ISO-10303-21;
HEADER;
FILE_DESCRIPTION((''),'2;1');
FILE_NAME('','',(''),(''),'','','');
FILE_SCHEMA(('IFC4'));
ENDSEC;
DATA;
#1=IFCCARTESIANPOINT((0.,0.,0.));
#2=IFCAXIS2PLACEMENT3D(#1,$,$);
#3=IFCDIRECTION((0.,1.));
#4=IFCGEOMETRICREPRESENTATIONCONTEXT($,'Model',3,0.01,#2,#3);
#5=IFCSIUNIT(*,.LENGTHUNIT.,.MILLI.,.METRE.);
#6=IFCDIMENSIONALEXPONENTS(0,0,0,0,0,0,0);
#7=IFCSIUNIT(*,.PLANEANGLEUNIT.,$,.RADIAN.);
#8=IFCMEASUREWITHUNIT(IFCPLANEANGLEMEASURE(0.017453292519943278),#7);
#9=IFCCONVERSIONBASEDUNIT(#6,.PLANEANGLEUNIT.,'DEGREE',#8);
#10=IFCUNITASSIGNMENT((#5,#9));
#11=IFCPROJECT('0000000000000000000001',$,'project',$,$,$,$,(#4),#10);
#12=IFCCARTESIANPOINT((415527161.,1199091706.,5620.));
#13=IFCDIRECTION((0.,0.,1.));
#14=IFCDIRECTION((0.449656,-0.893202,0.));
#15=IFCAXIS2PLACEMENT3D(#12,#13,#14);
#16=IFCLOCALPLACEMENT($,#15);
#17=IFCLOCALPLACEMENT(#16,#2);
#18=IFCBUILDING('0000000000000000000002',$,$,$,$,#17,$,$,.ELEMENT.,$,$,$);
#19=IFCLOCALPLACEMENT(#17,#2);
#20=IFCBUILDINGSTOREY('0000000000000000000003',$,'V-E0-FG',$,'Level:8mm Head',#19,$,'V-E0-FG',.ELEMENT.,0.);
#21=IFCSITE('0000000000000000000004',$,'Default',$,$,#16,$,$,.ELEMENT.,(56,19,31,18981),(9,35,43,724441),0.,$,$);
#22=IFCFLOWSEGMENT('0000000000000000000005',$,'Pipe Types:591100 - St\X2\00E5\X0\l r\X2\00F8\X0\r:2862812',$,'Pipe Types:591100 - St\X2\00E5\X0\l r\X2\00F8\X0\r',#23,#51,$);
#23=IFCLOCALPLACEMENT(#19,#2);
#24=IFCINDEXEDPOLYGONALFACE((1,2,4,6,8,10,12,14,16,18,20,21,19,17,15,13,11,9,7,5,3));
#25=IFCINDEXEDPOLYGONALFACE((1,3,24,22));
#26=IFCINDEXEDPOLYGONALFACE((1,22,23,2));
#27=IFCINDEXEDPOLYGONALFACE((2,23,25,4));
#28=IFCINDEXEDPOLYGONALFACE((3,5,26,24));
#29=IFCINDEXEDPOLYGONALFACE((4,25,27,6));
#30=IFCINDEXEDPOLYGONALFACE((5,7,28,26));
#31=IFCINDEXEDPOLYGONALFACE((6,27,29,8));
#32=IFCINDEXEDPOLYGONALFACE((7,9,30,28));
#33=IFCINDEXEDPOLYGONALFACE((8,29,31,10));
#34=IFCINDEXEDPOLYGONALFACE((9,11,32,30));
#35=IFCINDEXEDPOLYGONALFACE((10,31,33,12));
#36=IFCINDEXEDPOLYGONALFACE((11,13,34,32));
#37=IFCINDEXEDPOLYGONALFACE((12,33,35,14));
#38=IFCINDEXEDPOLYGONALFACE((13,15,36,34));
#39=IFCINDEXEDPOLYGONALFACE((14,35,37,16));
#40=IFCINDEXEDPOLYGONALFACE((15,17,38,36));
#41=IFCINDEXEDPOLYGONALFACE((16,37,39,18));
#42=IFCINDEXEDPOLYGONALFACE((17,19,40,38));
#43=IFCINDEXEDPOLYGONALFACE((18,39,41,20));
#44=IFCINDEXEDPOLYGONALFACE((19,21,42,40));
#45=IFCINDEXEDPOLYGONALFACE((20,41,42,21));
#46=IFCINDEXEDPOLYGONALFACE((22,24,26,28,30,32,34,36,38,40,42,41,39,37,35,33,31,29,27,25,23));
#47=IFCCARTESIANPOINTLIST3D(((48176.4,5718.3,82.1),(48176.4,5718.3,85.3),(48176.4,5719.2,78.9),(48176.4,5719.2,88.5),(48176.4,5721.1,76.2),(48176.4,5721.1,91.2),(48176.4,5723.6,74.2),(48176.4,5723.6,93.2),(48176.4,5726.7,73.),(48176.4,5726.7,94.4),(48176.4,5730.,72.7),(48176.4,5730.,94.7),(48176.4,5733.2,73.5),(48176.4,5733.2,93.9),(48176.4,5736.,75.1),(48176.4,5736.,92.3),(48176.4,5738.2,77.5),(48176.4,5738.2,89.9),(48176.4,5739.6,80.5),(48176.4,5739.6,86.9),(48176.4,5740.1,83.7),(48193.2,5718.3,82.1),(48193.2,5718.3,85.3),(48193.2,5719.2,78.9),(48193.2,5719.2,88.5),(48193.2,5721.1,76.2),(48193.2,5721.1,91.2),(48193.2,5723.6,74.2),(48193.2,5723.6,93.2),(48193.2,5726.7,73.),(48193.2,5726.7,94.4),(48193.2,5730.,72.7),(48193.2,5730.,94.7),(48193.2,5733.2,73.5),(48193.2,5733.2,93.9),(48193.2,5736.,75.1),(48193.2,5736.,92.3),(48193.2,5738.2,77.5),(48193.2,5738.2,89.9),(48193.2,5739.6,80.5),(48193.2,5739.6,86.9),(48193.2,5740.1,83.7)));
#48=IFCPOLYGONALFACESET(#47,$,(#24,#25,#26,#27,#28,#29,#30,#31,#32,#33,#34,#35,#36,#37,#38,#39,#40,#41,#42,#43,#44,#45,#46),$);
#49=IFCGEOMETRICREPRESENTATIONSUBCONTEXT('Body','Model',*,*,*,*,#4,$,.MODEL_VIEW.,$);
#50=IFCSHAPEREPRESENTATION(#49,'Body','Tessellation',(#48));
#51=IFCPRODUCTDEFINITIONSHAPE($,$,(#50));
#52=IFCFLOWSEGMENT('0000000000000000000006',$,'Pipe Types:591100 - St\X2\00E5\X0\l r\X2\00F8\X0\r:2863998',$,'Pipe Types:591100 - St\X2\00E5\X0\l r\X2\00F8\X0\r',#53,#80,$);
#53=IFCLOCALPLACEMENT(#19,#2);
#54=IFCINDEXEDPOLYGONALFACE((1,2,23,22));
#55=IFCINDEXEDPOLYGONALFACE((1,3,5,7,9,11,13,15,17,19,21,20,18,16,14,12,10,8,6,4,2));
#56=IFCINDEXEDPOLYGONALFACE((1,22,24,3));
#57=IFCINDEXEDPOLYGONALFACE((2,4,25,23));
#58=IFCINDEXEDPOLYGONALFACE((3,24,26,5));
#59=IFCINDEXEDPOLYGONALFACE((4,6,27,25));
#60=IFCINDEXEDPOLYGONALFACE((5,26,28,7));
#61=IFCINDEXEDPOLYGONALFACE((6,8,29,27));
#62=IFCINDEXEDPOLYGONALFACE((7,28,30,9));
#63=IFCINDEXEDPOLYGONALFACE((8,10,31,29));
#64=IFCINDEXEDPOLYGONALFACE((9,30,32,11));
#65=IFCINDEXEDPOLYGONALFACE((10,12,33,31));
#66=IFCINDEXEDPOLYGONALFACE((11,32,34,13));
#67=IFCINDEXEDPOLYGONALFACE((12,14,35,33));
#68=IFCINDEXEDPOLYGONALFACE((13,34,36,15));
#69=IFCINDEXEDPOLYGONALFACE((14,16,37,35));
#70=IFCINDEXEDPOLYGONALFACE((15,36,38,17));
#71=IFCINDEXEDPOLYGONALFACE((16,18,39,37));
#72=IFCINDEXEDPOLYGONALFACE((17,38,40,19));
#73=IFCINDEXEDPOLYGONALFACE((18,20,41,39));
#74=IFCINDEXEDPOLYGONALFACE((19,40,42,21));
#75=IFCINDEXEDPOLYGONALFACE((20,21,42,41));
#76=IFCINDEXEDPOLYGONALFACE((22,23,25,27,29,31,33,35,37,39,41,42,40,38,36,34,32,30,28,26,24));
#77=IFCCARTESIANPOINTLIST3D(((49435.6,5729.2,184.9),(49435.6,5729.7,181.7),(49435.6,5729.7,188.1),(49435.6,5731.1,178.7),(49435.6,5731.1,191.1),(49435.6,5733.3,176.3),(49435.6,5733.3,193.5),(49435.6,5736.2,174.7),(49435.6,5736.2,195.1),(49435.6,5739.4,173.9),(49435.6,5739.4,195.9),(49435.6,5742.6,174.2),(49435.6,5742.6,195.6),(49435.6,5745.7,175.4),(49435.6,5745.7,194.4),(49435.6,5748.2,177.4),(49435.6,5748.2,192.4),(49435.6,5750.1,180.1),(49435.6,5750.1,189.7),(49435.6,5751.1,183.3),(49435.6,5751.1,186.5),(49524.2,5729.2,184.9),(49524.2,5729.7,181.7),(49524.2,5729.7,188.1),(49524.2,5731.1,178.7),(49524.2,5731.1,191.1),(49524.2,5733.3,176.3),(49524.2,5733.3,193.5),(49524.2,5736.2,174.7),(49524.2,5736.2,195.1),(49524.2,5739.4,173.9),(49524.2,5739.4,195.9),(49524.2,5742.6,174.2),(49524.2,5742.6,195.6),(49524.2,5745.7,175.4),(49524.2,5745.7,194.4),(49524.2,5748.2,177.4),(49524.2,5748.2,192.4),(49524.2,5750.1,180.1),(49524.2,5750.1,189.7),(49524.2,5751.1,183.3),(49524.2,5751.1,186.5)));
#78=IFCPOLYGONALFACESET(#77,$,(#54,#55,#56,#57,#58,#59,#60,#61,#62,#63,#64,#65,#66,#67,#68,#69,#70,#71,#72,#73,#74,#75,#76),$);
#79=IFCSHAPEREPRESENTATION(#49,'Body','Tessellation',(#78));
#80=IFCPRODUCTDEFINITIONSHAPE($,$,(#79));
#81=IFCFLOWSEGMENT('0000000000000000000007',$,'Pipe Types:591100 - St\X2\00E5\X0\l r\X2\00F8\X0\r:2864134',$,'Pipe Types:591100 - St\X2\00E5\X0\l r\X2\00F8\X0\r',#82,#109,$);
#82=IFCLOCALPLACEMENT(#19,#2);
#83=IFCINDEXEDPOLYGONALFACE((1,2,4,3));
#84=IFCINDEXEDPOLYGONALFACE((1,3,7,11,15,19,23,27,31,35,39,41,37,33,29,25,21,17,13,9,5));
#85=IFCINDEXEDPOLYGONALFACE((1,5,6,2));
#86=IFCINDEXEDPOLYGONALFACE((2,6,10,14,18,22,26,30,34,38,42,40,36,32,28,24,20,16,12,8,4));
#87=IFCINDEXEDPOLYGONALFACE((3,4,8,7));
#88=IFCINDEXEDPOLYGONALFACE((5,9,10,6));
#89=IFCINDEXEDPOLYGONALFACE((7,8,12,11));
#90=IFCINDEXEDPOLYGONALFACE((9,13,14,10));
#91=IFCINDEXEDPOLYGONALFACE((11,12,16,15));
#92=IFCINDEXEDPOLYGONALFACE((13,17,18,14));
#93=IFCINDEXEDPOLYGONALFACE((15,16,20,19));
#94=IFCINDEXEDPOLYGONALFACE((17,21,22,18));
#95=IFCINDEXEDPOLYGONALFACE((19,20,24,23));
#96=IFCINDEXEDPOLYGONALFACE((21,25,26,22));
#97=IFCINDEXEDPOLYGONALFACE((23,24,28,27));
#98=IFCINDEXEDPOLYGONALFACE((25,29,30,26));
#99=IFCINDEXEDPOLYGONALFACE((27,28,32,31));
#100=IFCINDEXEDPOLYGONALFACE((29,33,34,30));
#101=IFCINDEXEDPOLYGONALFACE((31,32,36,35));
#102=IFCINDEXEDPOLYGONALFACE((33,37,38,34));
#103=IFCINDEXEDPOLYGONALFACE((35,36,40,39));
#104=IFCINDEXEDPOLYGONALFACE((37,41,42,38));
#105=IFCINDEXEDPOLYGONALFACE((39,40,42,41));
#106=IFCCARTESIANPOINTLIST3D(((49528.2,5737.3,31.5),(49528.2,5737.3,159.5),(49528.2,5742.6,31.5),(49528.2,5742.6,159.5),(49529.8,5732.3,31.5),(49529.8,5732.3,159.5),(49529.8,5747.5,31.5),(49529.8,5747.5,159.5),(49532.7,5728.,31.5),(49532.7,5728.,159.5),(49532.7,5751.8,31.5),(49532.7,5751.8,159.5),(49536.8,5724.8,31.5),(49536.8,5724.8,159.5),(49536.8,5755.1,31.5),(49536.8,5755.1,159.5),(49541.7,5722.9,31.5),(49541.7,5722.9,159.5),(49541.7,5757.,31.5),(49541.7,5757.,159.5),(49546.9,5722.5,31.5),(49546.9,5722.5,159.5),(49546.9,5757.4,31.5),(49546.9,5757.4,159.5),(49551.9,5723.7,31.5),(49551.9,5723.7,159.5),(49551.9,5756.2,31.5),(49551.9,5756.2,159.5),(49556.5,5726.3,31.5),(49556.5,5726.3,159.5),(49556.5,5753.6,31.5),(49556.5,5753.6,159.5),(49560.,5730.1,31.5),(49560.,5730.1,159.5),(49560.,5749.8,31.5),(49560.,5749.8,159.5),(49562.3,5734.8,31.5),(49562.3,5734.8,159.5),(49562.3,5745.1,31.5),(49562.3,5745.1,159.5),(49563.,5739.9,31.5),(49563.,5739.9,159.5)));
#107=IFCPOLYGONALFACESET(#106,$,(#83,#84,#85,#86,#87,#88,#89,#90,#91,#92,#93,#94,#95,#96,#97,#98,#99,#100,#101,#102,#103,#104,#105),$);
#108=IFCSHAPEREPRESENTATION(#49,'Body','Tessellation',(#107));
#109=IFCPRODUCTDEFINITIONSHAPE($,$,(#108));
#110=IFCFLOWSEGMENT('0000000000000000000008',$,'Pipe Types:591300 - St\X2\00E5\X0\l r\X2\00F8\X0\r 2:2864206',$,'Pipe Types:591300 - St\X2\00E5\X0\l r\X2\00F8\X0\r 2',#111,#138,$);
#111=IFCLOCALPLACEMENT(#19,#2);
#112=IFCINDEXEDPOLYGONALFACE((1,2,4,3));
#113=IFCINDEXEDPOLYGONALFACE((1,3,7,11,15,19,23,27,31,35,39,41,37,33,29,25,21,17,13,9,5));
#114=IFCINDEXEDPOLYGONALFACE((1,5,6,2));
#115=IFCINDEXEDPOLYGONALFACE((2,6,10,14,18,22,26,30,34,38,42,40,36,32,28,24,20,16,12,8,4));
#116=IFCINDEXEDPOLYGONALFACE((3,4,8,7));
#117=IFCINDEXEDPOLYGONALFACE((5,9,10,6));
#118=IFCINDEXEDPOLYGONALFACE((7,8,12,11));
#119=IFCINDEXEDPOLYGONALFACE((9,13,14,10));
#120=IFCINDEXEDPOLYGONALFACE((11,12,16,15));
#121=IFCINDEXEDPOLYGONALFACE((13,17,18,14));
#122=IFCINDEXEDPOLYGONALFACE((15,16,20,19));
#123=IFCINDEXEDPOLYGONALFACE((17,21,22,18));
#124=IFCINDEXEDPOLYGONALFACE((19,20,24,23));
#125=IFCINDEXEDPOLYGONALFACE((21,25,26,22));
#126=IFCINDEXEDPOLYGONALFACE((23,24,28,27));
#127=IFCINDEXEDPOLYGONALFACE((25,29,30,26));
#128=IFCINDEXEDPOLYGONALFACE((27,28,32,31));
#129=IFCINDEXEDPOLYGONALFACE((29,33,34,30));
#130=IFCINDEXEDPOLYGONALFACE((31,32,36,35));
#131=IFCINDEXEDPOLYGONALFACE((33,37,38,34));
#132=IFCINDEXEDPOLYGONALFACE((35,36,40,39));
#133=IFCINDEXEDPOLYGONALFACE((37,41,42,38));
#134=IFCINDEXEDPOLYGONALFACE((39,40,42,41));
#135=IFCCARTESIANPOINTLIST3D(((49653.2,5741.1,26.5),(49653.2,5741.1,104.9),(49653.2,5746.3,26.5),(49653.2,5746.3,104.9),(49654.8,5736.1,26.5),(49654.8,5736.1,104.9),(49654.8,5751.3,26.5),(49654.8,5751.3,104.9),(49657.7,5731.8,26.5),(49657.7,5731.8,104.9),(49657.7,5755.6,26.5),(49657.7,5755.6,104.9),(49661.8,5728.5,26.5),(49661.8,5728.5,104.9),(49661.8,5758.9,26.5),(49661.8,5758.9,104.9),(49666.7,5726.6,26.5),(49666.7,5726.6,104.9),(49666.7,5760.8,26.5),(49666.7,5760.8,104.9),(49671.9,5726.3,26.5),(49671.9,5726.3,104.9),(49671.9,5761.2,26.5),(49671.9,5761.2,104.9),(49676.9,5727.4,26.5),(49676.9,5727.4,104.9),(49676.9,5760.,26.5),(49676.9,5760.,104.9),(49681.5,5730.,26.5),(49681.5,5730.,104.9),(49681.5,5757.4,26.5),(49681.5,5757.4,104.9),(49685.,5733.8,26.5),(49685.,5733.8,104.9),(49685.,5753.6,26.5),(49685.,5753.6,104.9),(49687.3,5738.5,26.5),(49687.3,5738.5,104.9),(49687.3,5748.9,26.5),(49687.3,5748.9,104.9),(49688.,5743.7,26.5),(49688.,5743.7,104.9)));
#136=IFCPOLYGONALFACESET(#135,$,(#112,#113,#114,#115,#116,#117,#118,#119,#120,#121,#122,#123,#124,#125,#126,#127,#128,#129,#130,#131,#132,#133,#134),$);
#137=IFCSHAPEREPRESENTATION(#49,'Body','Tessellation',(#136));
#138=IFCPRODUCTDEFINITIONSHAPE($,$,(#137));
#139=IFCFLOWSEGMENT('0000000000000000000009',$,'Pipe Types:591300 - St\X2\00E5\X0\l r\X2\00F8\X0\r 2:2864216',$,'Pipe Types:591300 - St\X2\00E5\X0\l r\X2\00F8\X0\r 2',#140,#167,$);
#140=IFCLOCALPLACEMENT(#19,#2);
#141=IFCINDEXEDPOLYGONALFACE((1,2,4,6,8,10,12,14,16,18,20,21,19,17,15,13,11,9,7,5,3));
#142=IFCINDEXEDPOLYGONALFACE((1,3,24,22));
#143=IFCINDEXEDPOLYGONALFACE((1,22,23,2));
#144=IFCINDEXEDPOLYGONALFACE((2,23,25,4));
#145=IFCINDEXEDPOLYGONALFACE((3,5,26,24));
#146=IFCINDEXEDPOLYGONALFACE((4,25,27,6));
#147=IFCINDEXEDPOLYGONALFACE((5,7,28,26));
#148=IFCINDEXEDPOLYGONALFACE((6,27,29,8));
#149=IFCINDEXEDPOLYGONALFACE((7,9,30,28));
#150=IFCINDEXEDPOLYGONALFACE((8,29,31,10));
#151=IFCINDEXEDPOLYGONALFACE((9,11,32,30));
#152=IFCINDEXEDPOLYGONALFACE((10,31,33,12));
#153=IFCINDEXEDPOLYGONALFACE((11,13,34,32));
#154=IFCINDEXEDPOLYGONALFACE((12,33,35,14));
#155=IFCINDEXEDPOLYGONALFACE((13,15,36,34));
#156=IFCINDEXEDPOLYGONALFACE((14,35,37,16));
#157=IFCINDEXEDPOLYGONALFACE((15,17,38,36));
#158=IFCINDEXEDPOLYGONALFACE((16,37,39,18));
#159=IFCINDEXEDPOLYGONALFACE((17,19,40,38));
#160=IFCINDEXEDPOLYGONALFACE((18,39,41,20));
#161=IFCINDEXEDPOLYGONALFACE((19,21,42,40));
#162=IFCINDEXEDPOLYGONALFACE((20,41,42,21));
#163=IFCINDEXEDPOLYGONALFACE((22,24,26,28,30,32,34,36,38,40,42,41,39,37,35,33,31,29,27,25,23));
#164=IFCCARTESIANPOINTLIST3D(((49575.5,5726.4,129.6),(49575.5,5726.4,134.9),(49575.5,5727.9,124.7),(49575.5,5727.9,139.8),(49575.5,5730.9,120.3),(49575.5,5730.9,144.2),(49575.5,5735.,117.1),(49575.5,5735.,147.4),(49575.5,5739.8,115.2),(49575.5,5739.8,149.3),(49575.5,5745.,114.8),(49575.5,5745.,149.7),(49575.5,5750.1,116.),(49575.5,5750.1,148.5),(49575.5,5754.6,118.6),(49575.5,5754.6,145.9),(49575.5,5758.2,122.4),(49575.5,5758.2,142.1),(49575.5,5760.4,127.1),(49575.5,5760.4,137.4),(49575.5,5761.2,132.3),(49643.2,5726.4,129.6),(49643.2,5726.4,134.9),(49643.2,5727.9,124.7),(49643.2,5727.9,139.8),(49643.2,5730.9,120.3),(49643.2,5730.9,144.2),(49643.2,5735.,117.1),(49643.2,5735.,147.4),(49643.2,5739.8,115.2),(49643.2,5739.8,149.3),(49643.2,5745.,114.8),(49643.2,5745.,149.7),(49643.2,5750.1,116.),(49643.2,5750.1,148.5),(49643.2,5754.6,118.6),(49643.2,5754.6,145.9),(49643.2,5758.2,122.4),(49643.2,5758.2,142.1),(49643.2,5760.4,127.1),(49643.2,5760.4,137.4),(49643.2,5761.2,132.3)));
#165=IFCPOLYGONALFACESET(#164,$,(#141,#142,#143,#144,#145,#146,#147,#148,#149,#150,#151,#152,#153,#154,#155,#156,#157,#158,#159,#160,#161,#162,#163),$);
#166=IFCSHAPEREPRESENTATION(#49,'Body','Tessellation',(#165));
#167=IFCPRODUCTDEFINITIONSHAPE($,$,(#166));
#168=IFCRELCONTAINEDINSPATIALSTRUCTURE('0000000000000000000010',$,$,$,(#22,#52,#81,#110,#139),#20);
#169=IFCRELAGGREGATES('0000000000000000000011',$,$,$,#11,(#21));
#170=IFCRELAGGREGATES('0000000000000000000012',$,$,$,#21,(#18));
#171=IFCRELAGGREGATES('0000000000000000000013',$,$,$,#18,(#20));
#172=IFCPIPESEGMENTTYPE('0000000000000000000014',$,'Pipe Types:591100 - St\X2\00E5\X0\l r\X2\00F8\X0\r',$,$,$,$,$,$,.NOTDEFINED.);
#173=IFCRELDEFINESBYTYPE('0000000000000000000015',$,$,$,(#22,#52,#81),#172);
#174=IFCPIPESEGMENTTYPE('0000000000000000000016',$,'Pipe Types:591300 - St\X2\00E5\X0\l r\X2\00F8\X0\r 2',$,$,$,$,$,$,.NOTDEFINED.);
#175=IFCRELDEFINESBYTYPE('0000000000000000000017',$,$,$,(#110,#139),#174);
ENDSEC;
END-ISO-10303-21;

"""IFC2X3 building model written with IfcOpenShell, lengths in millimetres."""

from ifc_helpers import new_model, entity, si_unit, converted_unit, direction, frame, frame_2d, origin, origin_2d_with_axis, place, context, subcontext, project, spatial, circle, extrude, type_object, element, save


model = new_model("IFC2X3")

# Units and contexts
model_context = context("Model", 3, precision=0.01, world=origin(), true_north=direction((0.0, 1.0)))
body_context = subcontext(model_context, "Body", "Model", "MODEL_VIEW")
ifc_project = project(units=[si_unit("LENGTHUNIT", "METRE", prefix="MILLI"), converted_unit("PLANEANGLEUNIT", "DEGREE", entity("IfcPlaneAngleMeasure", 0.017453292519943278), si_unit("PLANEANGLEUNIT", "RADIAN"), dimensions=[0, 0, 0, 0, 0, 0, 0])], contexts=[model_context])

# Site, building, storey
site_placement = place(None, frame((415527161.0, 1199091706.0, 5620.0), z_axis=(0.0, 0.0, 1.0), x_axis=(0.449656, -0.893202, 0.0)))
site = spatial("IfcSite", under=ifc_project, at=site_placement, Name="Default", CompositionType="ELEMENT", RefLatitude=(56, 19, 31, 18981), RefLongitude=(9, 35, 43, 724441), RefElevation=0.0)
building_placement = place(site_placement, origin())
building = spatial("IfcBuilding", under=site, at=building_placement, CompositionType="ELEMENT")
storey_placement = place(building_placement, origin())
storey = spatial("IfcBuildingStorey", under=building, at=storey_placement, Name="V-E0-FG", ObjectType="Level:8mm Head", LongName="V-E0-FG", CompositionType="ELEMENT", Elevation=0.0)

# Flow segments
pipe_segment_type_1 = type_object("IfcPipeSegmentType", Name="Pipe Types:591100 - Stål rør", PredefinedType="NOTDEFINED")
flow_segment_1_placement = place(storey_placement, origin())
element("IfcFlowSegment", 1, at=flow_segment_1_placement, inside=storey, type_object=pipe_segment_type_1, Name="Pipe Types:591100 - Stål rør:2862812", ObjectType="Pipe Types:591100 - Stål rør", context=body_context, shape_type="SweptSolid", body=[
    extrude(circle(Radius=11.0, at=origin_2d_with_axis()), frame((48176.4, 5729.1, 83.7), z_axis=(1.0, 0.0, 0.0), x_axis=(0.0, 1.0, 0.0)), (0.0, 0.0, 1.0), 16.8),
])
flow_segment_2_placement = place(storey_placement, origin())
element("IfcFlowSegment", 2, at=flow_segment_2_placement, inside=storey, type_object=pipe_segment_type_1, Name="Pipe Types:591100 - Stål rør:2863998", ObjectType="Pipe Types:591100 - Stål rør", context=body_context, shape_type="SweptSolid", body=[
    extrude(circle(Radius=11.0, at=origin_2d_with_axis()), frame((49435.6, 5740.2, 184.9), z_axis=(1.0, 0.0, 0.0), x_axis=(0.0, -1.0, 0.0)), (0.0, 0.0, 1.0), 88.6),
])
flow_segment_3_placement = place(storey_placement, origin())
element("IfcFlowSegment", 3, at=flow_segment_3_placement, inside=storey, type_object=pipe_segment_type_1, Name="Pipe Types:591100 - Stål rør:2864134", ObjectType="Pipe Types:591100 - Stål rør", context=body_context, shape_type="SweptSolid", body=[
    extrude(circle(Radius=17.5, at=origin_2d_with_axis()), frame((49545.5, 5739.9, 31.5)), (0.0, 0.0, 1.0), 128.0),
])
pipe_segment_type_2 = type_object("IfcPipeSegmentType", Name="Pipe Types:591300 - Stål rør 2", PredefinedType="NOTDEFINED")
flow_segment_4_placement = place(storey_placement, origin())
element("IfcFlowSegment", 4, at=flow_segment_4_placement, inside=storey, type_object=pipe_segment_type_2, Name="Pipe Types:591300 - Stål rør 2:2864206", ObjectType="Pipe Types:591300 - Stål rør 2", context=body_context, shape_type="SweptSolid", body=[
    extrude(circle(Radius=17.5, at=origin_2d_with_axis()), frame((49670.5, 5743.7, 26.5)), (0.0, 0.0, 1.0), 78.4),
])
flow_segment_5_placement = place(storey_placement, origin())
element("IfcFlowSegment", 5, at=flow_segment_5_placement, inside=storey, type_object=pipe_segment_type_2, Name="Pipe Types:591300 - Stål rør 2:2864216", ObjectType="Pipe Types:591300 - Stål rør 2", context=body_context, shape_type="SweptSolid", body=[
    extrude(circle(Radius=17.5, at=frame_2d((0.0, 0.0), x_axis=(1.0, 0.0))), frame((49575.5, 5743.7, 132.3), z_axis=(1.0, 0.0, 0.0), x_axis=(0.0, 1.0, 0.0)), (0.0, 0.0, 1.0), 67.7),
])

save(model, "model.ifc")
